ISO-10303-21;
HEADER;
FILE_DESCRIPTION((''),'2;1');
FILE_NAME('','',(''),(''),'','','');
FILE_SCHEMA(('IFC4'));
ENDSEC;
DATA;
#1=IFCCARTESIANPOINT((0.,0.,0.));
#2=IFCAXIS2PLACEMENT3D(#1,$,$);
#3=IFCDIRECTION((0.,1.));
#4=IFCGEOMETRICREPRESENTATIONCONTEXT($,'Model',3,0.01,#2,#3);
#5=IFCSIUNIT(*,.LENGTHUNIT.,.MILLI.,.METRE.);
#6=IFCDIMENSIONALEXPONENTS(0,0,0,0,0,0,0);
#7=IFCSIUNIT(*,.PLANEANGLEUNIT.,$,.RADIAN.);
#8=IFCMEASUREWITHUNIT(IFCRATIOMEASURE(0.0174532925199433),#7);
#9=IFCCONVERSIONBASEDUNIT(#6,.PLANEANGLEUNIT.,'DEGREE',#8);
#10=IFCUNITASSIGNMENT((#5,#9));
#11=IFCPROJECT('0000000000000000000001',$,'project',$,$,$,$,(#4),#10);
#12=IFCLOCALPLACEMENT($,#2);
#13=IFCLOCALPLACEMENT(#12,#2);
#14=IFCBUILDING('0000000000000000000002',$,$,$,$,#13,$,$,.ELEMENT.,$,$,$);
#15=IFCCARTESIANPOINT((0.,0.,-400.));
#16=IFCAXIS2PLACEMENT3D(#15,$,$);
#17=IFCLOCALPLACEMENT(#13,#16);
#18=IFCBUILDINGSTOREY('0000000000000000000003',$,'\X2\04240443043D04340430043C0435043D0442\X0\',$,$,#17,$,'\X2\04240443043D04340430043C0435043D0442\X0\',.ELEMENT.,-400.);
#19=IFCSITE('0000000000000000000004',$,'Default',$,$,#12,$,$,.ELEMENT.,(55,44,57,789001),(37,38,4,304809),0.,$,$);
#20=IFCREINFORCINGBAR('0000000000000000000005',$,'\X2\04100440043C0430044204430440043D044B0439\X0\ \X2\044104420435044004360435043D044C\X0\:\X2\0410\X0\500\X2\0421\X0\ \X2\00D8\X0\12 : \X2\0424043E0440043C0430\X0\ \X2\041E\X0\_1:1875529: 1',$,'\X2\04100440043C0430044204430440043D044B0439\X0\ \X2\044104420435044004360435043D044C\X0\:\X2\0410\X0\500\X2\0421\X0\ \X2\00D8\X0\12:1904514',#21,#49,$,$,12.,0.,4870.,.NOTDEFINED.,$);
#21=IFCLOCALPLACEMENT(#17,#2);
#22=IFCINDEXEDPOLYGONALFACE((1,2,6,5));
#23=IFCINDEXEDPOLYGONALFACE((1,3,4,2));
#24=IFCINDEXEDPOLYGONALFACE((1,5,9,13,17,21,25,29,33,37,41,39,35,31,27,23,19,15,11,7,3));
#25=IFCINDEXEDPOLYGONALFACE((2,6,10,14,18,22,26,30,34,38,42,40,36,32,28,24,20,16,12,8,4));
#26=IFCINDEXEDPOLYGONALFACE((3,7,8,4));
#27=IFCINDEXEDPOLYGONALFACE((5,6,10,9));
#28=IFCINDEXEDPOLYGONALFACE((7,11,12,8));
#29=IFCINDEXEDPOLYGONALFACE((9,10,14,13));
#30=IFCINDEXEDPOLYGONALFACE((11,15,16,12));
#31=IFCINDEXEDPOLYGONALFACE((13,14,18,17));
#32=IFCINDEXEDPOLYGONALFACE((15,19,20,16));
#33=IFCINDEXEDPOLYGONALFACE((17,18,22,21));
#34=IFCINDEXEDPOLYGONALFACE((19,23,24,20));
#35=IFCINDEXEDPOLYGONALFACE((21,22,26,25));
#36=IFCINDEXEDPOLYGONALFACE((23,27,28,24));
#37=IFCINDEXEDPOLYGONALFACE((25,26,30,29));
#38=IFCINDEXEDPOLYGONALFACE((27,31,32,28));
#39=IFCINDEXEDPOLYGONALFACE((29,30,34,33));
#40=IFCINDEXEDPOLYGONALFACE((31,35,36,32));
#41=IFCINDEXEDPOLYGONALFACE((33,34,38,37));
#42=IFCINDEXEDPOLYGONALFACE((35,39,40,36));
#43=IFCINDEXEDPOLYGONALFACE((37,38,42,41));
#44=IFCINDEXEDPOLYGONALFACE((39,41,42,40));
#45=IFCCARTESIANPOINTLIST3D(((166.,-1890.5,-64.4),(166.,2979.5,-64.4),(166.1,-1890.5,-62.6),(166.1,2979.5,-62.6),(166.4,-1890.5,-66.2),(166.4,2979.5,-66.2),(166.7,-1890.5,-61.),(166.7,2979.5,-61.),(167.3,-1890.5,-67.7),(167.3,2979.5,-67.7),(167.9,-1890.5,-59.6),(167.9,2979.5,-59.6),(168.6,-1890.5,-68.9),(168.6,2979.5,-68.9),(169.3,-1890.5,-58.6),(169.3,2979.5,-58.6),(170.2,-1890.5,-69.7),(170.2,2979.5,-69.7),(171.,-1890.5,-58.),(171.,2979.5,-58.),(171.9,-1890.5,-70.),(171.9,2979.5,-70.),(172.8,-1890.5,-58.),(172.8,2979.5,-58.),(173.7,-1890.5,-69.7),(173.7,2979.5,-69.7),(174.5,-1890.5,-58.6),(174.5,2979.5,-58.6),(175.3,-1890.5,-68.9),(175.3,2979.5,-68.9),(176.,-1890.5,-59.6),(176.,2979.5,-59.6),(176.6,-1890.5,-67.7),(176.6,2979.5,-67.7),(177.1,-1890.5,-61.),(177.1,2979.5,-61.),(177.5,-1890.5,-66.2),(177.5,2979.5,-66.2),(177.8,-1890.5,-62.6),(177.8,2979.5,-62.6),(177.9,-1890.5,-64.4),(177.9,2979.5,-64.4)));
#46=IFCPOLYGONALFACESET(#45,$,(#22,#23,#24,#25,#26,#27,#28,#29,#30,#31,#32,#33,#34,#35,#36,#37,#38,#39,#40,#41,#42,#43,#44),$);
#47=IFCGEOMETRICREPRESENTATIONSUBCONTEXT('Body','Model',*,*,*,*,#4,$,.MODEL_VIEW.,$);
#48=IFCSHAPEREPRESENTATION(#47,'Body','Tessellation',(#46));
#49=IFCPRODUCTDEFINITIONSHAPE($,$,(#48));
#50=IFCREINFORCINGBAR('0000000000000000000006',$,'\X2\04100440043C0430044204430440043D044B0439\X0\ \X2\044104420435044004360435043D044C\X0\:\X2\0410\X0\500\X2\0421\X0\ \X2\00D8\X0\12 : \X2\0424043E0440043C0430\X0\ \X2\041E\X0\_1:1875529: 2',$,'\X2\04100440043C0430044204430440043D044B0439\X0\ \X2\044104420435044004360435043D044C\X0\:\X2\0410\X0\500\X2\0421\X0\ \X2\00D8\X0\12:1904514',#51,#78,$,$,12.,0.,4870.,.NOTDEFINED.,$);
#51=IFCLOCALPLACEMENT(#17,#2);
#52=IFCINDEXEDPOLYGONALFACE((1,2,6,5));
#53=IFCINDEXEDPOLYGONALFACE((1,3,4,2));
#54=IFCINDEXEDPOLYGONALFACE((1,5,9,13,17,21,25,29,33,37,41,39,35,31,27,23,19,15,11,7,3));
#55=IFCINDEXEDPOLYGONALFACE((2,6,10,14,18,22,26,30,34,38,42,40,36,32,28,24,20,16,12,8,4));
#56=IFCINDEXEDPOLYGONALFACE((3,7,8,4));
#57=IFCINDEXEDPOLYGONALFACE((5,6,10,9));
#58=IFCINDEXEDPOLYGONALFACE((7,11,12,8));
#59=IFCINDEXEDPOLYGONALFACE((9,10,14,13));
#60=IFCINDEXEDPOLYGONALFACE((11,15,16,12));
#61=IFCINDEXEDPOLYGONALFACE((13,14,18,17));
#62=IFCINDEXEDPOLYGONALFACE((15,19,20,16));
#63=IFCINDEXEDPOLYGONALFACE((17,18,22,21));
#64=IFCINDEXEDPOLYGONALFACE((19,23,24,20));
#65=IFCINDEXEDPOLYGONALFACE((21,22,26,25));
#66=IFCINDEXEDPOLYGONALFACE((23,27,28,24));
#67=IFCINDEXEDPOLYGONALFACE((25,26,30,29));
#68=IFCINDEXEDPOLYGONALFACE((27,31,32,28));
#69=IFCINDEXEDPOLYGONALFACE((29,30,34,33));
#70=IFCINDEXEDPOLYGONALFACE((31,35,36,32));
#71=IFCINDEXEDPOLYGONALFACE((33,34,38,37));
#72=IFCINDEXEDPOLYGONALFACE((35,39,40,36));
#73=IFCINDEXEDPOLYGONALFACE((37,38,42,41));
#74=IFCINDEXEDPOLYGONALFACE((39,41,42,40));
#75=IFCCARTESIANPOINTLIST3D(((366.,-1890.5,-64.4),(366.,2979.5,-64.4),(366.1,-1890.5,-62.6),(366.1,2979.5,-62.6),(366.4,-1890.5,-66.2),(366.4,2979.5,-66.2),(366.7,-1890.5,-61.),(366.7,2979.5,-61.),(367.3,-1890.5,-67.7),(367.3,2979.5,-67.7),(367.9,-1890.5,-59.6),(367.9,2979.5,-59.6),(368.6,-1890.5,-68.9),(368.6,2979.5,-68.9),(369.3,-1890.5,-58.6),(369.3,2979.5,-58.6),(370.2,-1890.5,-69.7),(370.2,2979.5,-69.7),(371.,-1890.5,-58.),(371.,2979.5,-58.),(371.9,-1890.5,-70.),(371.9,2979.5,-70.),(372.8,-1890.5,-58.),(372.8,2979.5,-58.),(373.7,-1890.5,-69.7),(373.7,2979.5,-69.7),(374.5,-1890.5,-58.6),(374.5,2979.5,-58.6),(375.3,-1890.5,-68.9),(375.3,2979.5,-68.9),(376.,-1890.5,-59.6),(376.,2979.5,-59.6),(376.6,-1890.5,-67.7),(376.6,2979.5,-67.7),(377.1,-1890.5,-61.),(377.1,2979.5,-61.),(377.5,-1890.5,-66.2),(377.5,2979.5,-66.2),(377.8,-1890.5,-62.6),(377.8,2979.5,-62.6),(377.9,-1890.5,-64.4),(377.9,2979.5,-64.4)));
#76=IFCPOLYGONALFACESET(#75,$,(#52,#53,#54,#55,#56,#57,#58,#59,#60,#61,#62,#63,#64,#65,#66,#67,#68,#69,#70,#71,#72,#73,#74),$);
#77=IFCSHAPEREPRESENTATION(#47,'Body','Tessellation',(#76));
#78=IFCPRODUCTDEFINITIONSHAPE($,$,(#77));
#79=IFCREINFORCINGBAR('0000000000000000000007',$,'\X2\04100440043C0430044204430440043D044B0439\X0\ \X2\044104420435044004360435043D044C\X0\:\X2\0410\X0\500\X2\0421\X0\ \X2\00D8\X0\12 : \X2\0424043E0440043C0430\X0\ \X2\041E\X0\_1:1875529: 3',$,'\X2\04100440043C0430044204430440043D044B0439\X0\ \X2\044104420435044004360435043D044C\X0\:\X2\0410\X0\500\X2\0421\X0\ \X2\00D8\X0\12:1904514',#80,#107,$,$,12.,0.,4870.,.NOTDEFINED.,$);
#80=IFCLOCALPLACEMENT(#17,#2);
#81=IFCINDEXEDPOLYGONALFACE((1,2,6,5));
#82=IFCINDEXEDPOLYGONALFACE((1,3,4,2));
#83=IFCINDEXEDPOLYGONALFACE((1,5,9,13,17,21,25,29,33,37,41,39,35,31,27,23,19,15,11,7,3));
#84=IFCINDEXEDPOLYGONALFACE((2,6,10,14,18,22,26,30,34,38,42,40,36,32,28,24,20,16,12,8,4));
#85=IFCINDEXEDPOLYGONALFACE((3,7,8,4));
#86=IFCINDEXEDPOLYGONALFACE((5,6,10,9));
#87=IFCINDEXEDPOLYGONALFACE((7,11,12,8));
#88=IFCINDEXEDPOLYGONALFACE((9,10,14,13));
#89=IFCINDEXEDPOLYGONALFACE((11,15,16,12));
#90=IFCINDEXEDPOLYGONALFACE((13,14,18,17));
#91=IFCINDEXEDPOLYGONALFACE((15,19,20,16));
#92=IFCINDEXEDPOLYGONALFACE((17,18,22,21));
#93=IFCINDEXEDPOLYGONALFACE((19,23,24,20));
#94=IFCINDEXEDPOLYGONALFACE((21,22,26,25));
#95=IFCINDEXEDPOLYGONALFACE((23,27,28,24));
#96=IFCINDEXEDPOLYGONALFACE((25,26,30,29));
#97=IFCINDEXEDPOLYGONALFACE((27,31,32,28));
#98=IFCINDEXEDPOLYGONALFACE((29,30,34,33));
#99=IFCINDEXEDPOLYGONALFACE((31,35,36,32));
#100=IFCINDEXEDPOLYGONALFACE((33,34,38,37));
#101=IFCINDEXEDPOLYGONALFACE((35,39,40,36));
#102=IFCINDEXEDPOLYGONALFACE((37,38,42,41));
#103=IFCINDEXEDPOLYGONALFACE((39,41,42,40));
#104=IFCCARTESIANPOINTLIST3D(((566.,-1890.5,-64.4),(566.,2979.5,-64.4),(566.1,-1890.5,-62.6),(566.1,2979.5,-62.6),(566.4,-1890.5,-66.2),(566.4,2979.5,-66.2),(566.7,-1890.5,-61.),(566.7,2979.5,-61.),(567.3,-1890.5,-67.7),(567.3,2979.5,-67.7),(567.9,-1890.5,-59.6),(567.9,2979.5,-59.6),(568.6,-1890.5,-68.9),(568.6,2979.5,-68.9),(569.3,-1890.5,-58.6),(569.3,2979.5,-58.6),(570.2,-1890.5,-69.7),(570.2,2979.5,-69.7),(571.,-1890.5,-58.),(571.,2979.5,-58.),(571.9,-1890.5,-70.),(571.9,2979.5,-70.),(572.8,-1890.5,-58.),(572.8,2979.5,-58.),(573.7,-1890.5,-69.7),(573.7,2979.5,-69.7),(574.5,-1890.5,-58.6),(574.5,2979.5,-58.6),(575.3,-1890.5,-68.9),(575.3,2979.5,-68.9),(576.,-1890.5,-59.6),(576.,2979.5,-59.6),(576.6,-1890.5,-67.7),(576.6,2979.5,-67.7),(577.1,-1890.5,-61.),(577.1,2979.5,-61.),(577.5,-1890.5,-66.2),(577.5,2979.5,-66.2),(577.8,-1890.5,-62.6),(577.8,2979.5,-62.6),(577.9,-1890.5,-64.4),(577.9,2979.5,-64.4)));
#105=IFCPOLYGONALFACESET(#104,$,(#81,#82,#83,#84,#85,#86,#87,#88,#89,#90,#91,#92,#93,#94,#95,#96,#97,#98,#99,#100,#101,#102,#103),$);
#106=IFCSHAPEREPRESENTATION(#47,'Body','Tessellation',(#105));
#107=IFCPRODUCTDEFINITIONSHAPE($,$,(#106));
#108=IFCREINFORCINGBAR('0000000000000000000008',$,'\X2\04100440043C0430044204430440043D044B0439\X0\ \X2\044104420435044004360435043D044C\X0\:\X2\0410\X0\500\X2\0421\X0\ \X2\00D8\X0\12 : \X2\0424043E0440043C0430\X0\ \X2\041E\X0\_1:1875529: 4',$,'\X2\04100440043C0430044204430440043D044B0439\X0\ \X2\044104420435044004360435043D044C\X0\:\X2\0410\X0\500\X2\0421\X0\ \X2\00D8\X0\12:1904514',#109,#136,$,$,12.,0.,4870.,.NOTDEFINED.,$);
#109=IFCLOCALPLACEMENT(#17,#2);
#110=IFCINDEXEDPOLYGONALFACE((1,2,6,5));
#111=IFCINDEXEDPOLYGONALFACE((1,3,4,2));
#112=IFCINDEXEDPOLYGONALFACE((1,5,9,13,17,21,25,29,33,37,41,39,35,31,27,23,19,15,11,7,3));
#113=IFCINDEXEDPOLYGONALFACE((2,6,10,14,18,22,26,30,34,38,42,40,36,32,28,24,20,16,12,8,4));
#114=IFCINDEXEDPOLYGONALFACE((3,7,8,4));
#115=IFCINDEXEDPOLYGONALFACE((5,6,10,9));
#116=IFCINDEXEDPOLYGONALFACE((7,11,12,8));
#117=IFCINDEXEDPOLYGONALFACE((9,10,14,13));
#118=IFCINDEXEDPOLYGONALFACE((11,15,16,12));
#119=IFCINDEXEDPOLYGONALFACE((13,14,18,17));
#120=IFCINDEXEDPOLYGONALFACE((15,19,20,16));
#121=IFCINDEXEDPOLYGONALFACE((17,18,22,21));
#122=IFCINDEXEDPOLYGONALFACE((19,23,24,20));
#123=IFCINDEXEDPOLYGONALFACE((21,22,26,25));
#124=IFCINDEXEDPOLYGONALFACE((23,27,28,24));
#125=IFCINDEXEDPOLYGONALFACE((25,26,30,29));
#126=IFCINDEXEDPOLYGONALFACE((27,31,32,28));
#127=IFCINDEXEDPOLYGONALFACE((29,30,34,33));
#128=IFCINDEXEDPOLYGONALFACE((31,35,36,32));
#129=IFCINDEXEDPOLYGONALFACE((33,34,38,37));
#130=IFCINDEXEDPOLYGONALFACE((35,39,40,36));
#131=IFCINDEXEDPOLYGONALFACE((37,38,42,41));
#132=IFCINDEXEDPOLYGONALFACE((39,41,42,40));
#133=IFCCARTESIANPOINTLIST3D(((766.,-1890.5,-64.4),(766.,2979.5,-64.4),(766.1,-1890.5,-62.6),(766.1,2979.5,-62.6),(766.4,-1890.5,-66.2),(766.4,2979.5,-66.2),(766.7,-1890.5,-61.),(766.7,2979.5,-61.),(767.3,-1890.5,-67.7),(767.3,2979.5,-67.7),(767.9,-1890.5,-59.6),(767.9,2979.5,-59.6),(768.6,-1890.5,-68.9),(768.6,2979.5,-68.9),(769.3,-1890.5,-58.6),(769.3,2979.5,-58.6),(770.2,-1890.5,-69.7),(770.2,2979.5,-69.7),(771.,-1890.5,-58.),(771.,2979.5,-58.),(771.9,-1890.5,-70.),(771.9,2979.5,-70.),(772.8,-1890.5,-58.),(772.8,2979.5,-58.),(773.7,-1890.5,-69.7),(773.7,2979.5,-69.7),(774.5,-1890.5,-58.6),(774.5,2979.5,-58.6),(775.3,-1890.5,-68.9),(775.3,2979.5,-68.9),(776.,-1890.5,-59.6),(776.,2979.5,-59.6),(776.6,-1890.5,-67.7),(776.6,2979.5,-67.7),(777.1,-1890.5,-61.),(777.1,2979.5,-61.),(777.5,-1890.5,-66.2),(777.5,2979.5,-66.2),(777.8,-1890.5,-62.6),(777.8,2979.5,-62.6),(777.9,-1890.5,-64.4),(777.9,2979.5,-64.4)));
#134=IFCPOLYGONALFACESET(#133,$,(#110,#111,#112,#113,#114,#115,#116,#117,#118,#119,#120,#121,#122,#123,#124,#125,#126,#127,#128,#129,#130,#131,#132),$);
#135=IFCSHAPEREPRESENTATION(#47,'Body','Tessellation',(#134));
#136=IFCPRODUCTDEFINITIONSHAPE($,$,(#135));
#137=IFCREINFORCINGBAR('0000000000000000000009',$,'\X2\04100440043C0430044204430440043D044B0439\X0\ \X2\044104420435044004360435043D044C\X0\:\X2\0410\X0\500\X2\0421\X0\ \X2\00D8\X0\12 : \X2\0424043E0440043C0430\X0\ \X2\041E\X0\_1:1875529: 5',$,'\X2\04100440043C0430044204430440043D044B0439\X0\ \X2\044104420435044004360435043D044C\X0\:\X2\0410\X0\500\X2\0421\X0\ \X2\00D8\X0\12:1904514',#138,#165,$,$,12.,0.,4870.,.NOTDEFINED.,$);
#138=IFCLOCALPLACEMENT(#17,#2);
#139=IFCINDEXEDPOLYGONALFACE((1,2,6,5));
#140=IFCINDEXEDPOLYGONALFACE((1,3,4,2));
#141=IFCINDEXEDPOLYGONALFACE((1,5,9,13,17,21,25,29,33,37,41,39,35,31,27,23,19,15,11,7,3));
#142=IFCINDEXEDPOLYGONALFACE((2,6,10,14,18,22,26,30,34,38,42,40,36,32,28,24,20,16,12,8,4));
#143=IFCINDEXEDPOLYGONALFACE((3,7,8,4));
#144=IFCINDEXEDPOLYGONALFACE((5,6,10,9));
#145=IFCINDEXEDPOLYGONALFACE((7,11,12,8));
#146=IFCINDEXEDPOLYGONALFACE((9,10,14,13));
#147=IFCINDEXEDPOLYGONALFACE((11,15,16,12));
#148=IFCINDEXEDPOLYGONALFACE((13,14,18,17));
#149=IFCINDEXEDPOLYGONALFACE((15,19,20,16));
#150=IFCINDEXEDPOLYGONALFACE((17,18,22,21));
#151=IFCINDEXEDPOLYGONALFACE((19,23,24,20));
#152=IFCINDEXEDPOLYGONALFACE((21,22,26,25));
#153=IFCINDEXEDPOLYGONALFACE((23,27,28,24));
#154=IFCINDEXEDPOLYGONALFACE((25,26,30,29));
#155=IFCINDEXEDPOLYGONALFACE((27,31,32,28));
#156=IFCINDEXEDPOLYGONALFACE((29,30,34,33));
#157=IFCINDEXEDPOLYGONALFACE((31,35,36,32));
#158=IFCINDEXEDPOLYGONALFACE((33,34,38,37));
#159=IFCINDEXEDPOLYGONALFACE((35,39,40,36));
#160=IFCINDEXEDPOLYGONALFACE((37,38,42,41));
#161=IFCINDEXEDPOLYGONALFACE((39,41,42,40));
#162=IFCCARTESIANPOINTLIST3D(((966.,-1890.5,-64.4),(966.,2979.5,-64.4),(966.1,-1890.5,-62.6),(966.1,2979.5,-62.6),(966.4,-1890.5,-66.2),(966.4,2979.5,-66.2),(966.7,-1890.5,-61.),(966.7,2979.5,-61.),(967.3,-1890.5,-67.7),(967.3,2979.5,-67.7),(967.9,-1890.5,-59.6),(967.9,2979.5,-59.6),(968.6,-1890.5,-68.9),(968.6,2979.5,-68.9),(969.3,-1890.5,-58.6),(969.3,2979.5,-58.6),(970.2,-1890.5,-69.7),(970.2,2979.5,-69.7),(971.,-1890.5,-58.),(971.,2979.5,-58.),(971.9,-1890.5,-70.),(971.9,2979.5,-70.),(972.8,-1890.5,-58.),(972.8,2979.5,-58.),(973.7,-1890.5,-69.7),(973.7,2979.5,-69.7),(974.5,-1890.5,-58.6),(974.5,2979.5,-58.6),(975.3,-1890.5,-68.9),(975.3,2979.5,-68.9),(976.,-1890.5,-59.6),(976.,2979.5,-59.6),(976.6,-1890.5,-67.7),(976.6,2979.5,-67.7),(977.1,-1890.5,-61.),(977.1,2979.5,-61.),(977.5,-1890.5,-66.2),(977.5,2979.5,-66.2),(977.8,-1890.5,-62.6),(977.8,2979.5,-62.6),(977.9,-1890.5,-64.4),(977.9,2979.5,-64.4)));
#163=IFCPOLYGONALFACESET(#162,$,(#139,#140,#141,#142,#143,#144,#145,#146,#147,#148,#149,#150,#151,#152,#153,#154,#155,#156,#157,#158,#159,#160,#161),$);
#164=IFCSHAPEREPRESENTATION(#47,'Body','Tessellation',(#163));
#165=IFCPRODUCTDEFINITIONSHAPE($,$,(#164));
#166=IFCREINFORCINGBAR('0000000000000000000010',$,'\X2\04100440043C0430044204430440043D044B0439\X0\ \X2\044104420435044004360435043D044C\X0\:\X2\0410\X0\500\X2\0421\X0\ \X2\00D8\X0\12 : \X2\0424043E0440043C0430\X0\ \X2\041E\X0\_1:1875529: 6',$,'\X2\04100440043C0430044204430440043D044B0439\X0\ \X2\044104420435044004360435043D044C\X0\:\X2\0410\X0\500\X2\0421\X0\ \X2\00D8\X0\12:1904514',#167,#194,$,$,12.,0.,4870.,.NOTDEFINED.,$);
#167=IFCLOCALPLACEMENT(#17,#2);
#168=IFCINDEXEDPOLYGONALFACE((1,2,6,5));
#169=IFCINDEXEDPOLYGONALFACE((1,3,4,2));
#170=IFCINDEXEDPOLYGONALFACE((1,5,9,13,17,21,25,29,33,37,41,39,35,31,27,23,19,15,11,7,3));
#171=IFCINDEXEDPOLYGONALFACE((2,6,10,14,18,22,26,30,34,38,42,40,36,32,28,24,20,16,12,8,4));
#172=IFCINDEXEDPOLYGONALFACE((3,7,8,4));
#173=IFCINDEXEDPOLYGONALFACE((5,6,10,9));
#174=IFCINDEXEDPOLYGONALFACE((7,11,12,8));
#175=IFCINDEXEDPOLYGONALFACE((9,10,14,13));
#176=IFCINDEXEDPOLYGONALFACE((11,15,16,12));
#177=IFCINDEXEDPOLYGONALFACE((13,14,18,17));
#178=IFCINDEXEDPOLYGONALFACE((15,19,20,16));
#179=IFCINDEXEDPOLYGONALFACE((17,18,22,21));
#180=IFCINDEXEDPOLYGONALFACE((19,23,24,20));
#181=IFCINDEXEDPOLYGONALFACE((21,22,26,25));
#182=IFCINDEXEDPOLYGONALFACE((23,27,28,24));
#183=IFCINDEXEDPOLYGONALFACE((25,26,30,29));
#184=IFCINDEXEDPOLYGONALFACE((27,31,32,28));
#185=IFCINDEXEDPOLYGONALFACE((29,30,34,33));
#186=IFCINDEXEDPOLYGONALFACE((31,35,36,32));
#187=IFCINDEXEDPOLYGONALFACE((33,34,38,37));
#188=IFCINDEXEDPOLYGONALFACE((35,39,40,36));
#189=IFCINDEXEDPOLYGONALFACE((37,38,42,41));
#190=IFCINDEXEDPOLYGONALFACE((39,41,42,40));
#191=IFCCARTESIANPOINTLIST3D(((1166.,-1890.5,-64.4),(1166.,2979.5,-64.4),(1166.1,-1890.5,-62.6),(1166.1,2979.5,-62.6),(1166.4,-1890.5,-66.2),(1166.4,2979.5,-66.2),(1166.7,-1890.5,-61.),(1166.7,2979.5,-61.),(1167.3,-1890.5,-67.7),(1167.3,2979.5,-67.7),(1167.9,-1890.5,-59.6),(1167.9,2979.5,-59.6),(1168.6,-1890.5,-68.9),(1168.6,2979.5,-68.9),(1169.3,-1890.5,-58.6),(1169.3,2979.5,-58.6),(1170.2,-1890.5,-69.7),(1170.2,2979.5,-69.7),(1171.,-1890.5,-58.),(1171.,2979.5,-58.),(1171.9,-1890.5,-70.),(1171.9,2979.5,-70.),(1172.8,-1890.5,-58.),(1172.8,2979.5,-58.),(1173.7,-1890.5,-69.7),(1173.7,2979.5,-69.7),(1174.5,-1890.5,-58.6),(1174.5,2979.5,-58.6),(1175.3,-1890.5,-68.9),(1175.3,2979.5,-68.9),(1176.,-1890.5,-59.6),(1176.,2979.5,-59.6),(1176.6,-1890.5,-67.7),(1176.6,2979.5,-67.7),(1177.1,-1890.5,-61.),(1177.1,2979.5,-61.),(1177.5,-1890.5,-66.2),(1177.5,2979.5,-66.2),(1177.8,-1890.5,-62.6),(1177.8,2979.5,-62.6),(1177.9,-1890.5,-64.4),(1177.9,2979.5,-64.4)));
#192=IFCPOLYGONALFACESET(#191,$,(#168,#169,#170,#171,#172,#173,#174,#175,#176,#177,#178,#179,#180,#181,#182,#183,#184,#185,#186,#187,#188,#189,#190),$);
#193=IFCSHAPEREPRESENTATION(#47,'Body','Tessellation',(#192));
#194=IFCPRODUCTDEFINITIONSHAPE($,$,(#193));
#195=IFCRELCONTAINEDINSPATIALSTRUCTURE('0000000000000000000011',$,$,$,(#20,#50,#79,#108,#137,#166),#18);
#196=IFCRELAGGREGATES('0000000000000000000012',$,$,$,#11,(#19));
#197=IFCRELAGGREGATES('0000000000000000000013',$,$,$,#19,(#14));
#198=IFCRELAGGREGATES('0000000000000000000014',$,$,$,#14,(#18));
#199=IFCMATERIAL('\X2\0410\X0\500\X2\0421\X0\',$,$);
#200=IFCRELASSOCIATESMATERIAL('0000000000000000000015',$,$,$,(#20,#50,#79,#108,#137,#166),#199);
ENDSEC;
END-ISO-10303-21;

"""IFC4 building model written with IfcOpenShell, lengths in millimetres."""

from ifc_helpers import new_model, entity, si_unit, converted_unit, direction, frame, origin, place, context, subcontext, project, spatial, material, element, save


model = new_model("IFC4")

# Units and contexts
model_context = context("Model", 3, precision=0.01, world=origin(), true_north=direction((0.0, 1.0)))
body_context = subcontext(model_context, "Body", "Model", "MODEL_VIEW")
ifc_project = project(units=[si_unit("LENGTHUNIT", "METRE", prefix="MILLI"), converted_unit("PLANEANGLEUNIT", "DEGREE", entity("IfcRatioMeasure", 0.0174532925199433), si_unit("PLANEANGLEUNIT", "RADIAN"), dimensions=[0, 0, 0, 0, 0, 0, 0])], contexts=[model_context])

# Site, building, storey
site_placement = place(None, origin())
site = spatial("IfcSite", under=ifc_project, at=site_placement, Name="Default", CompositionType="ELEMENT", RefLatitude=(55, 44, 57, 789001), RefLongitude=(37, 38, 4, 304809), RefElevation=0.0)
building_placement = place(site_placement, origin())
building = spatial("IfcBuilding", under=site, at=building_placement, CompositionType="ELEMENT")
storey_placement = place(building_placement, frame((0.0, 0.0, -400.0)))
storey = spatial("IfcBuildingStorey", under=building, at=storey_placement, Name="Фундамент", LongName="Фундамент", CompositionType="ELEMENT", Elevation=-400.0)

# Reinforcing bars
ifc_material = material(Name="А500С")
reinforcing_bar_1_placement = place(storey_placement, origin())
element("IfcReinforcingBar", 1, at=reinforcing_bar_1_placement, inside=storey, material=ifc_material, Name="Арматурный стержень:А500С Ø12 : Форма О_1:1875529: 1", ObjectType="Арматурный стержень:А500С Ø12:1904514", BarLength=4870.0, CrossSectionArea=0.0, NominalDiameter=12.0, PredefinedType="NOTDEFINED", context=body_context, shape_type="AdvancedSweptSolid", body=[
    entity("IfcSweptDiskSolid", entity("IfcCompositeCurve", [entity("IfcCompositeCurveSegment", "CONTINUOUS", True, entity("IfcPolyline", [entity("IfcCartesianPoint", [171.9, 2979.5, -64.0]), entity("IfcCartesianPoint", [171.9, -1890.5, -64.0])]))], False), 6.0, None, 0.0, 1.0),
])
reinforcing_bar_2_placement = place(storey_placement, origin())
element("IfcReinforcingBar", 2, at=reinforcing_bar_2_placement, inside=storey, material=ifc_material, Name="Арматурный стержень:А500С Ø12 : Форма О_1:1875529: 2", ObjectType="Арматурный стержень:А500С Ø12:1904514", BarLength=4870.0, CrossSectionArea=0.0, NominalDiameter=12.0, PredefinedType="NOTDEFINED", context=body_context, shape_type="AdvancedSweptSolid", body=[
    entity("IfcSweptDiskSolid", entity("IfcCompositeCurve", [entity("IfcCompositeCurveSegment", "CONTINUOUS", True, entity("IfcPolyline", [entity("IfcCartesianPoint", [371.9, 2979.5, -64.0]), entity("IfcCartesianPoint", [371.9, -1890.5, -64.0])]))], False), 6.0, None, 0.0, 1.0),
])
reinforcing_bar_3_placement = place(storey_placement, origin())
element("IfcReinforcingBar", 3, at=reinforcing_bar_3_placement, inside=storey, material=ifc_material, Name="Арматурный стержень:А500С Ø12 : Форма О_1:1875529: 3", ObjectType="Арматурный стержень:А500С Ø12:1904514", BarLength=4870.0, CrossSectionArea=0.0, NominalDiameter=12.0, PredefinedType="NOTDEFINED", context=body_context, shape_type="AdvancedSweptSolid", body=[
    entity("IfcSweptDiskSolid", entity("IfcCompositeCurve", [entity("IfcCompositeCurveSegment", "CONTINUOUS", True, entity("IfcPolyline", [entity("IfcCartesianPoint", [571.9, 2979.5, -64.0]), entity("IfcCartesianPoint", [571.9, -1890.5, -64.0])]))], False), 6.0, None, 0.0, 1.0),
])
reinforcing_bar_4_placement = place(storey_placement, origin())
element("IfcReinforcingBar", 4, at=reinforcing_bar_4_placement, inside=storey, material=ifc_material, Name="Арматурный стержень:А500С Ø12 : Форма О_1:1875529: 4", ObjectType="Арматурный стержень:А500С Ø12:1904514", BarLength=4870.0, CrossSectionArea=0.0, NominalDiameter=12.0, PredefinedType="NOTDEFINED", context=body_context, shape_type="AdvancedSweptSolid", body=[
    entity("IfcSweptDiskSolid", entity("IfcCompositeCurve", [entity("IfcCompositeCurveSegment", "CONTINUOUS", True, entity("IfcPolyline", [entity("IfcCartesianPoint", [771.9, 2979.5, -64.0]), entity("IfcCartesianPoint", [771.9, -1890.5, -64.0])]))], False), 6.0, None, 0.0, 1.0),
])
reinforcing_bar_5_placement = place(storey_placement, origin())
element("IfcReinforcingBar", 5, at=reinforcing_bar_5_placement, inside=storey, material=ifc_material, Name="Арматурный стержень:А500С Ø12 : Форма О_1:1875529: 5", ObjectType="Арматурный стержень:А500С Ø12:1904514", BarLength=4870.0, CrossSectionArea=0.0, NominalDiameter=12.0, PredefinedType="NOTDEFINED", context=body_context, shape_type="AdvancedSweptSolid", body=[
    entity("IfcSweptDiskSolid", entity("IfcCompositeCurve", [entity("IfcCompositeCurveSegment", "CONTINUOUS", True, entity("IfcPolyline", [entity("IfcCartesianPoint", [971.9, 2979.5, -64.0]), entity("IfcCartesianPoint", [971.9, -1890.5, -64.0])]))], False), 6.0, None, 0.0, 1.0),
])
reinforcing_bar_6_placement = place(storey_placement, origin())
element("IfcReinforcingBar", 6, at=reinforcing_bar_6_placement, inside=storey, material=ifc_material, Name="Арматурный стержень:А500С Ø12 : Форма О_1:1875529: 6", ObjectType="Арматурный стержень:А500С Ø12:1904514", BarLength=4870.0, CrossSectionArea=0.0, NominalDiameter=12.0, PredefinedType="NOTDEFINED", context=body_context, shape_type="AdvancedSweptSolid", body=[
    entity("IfcSweptDiskSolid", entity("IfcCompositeCurve", [entity("IfcCompositeCurveSegment", "CONTINUOUS", True, entity("IfcPolyline", [entity("IfcCartesianPoint", [1171.9, 2979.5, -64.0]), entity("IfcCartesianPoint", [1171.9, -1890.5, -64.0])]))], False), 6.0, None, 0.0, 1.0),
])

save(model, "model.ifc")
